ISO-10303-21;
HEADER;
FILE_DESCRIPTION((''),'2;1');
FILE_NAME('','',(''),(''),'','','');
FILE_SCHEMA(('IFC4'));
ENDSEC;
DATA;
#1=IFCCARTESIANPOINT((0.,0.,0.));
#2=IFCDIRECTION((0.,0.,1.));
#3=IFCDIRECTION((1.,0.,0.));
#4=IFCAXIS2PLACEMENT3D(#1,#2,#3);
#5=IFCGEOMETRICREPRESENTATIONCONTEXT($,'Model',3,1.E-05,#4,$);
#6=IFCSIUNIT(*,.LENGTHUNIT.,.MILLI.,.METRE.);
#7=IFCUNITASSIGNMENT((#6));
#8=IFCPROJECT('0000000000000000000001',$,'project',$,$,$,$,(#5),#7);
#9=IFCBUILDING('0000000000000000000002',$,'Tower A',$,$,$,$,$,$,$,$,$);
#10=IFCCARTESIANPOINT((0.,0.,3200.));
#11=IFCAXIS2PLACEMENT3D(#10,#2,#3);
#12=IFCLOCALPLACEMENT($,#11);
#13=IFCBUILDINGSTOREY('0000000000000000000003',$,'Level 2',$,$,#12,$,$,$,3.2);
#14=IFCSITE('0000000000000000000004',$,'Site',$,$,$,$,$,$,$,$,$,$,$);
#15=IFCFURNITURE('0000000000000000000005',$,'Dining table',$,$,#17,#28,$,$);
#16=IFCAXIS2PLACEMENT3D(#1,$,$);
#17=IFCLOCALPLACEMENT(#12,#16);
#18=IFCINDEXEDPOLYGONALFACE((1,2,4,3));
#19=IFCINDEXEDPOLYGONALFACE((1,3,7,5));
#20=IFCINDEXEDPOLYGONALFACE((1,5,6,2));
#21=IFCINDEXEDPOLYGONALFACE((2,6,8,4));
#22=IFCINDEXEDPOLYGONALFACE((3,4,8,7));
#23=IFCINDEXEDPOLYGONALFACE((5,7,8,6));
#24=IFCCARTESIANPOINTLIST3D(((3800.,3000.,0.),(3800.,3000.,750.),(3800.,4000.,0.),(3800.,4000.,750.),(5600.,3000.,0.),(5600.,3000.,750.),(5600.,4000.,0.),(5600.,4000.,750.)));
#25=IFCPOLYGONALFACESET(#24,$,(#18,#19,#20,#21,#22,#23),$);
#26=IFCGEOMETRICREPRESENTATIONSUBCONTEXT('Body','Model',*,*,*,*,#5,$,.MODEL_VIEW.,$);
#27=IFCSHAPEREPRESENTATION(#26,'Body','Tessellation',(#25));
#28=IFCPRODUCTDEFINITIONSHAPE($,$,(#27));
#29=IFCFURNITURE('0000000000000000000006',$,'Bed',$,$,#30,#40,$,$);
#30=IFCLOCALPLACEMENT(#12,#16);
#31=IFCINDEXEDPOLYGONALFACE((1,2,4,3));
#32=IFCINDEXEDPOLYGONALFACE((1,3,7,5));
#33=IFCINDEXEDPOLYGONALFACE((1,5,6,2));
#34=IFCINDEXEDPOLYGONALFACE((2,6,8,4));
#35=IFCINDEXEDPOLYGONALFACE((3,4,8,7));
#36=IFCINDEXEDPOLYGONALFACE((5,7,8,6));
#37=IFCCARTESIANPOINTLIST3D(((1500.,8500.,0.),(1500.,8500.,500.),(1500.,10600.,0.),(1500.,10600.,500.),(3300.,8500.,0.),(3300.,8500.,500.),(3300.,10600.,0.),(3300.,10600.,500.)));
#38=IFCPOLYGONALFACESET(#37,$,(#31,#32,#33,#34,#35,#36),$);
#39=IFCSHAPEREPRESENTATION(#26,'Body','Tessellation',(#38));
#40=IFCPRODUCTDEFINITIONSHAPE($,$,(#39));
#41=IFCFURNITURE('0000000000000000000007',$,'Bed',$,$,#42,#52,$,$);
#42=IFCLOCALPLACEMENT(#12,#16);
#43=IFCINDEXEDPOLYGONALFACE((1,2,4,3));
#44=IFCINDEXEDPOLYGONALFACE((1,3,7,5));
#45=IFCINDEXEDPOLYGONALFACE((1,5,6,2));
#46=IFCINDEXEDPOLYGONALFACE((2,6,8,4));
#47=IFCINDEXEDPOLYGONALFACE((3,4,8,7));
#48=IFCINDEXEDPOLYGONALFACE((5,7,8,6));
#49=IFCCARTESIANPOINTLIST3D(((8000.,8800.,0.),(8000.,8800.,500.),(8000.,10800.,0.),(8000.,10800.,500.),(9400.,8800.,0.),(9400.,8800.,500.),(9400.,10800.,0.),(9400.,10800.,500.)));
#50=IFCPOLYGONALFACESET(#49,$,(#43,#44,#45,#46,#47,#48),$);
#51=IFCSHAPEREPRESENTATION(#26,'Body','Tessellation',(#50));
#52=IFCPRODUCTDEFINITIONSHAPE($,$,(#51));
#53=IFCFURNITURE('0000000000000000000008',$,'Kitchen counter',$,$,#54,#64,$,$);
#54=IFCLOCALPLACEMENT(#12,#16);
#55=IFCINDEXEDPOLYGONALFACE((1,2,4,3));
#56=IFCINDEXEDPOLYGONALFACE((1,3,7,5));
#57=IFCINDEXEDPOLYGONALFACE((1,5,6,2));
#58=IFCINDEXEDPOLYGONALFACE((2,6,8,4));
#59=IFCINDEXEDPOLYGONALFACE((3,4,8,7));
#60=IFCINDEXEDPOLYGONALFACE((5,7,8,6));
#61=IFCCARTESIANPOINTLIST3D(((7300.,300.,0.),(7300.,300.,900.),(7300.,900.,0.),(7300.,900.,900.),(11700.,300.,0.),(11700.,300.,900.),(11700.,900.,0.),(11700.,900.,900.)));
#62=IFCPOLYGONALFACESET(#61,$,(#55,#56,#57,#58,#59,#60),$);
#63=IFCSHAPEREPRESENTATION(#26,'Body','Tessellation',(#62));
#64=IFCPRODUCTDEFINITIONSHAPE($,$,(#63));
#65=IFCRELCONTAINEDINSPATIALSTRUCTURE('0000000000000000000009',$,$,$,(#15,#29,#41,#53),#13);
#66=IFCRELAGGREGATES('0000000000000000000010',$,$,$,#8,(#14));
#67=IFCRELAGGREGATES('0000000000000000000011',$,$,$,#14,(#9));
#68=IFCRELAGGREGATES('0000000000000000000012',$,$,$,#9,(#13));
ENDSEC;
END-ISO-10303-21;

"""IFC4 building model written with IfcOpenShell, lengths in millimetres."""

from ifc_helpers import new_model, si_unit, frame, origin_with_axes, place, context, subcontext, project, spatial, indexed_curve, outline, extrude, element, save


model = new_model("IFC4")

# Units and contexts
model_context = context("Model", 3, precision=1e-05, world=origin_with_axes())
body_context = subcontext(model_context, "Body", "Model", "MODEL_VIEW")
ifc_project = project(units=[si_unit("LENGTHUNIT", "METRE", prefix="MILLI")], contexts=[model_context])

# Site, building, storey
site = spatial("IfcSite", under=ifc_project, Name="Site")
building = spatial("IfcBuilding", under=site, Name="Tower A")
storey_placement = place(None, frame((0.0, 0.0, 3200.0), z_axis=(0.0, 0.0, 1.0), x_axis=(1.0, 0.0, 0.0)))
storey = spatial("IfcBuildingStorey", under=building, at=storey_placement, Name="Level 2", Elevation=3.2)

# Furniture
furniture_1_placement = place(storey_placement, frame((3800.0, 3000.0, 0.0), z_axis=(0.0, 0.0, 1.0), x_axis=(1.0, 0.0, 0.0)))
element("IfcFurniture", 1, at=furniture_1_placement, inside=storey, Name="Dining table", context=body_context, shape_type="SweptSolid", body=[
    extrude(outline(indexed_curve([(0.0, 0.0), (1800.0, 0.0), (1800.0, 1000.0), (0.0, 1000.0)])), None, (0.0, 0.0, 1.0), 750.0),
])
furniture_2_placement = place(storey_placement, frame((1500.0, 8500.0, 0.0), z_axis=(0.0, 0.0, 1.0), x_axis=(1.0, 0.0, 0.0)))
element("IfcFurniture", 2, at=furniture_2_placement, inside=storey, Name="Bed", context=body_context, shape_type="SweptSolid", body=[
    extrude(outline(indexed_curve([(0.0, 0.0), (1800.0, 0.0), (1800.0, 2100.0), (0.0, 2100.0)])), None, (0.0, 0.0, 1.0), 500.0),
])
furniture_3_placement = place(storey_placement, frame((8000.0, 8800.0, 0.0), z_axis=(0.0, 0.0, 1.0), x_axis=(1.0, 0.0, 0.0)))
element("IfcFurniture", 3, at=furniture_3_placement, inside=storey, Name="Bed", context=body_context, shape_type="SweptSolid", body=[
    extrude(outline(indexed_curve([(0.0, 0.0), (1400.0, 0.0), (1400.0, 2000.0), (0.0, 2000.0)])), None, (0.0, 0.0, 1.0), 500.0),
])
furniture_4_placement = place(storey_placement, frame((7300.0, 300.0, 0.0), z_axis=(0.0, 0.0, 1.0), x_axis=(1.0, 0.0, 0.0)))
element("IfcFurniture", 4, at=furniture_4_placement, inside=storey, Name="Kitchen counter", context=body_context, shape_type="SweptSolid", body=[
    extrude(outline(indexed_curve([(0.0, 0.0), (4400.0, 0.0), (4400.0, 600.0), (0.0, 600.0)])), None, (0.0, 0.0, 1.0), 900.0),
])

save(model, "model.ifc")
